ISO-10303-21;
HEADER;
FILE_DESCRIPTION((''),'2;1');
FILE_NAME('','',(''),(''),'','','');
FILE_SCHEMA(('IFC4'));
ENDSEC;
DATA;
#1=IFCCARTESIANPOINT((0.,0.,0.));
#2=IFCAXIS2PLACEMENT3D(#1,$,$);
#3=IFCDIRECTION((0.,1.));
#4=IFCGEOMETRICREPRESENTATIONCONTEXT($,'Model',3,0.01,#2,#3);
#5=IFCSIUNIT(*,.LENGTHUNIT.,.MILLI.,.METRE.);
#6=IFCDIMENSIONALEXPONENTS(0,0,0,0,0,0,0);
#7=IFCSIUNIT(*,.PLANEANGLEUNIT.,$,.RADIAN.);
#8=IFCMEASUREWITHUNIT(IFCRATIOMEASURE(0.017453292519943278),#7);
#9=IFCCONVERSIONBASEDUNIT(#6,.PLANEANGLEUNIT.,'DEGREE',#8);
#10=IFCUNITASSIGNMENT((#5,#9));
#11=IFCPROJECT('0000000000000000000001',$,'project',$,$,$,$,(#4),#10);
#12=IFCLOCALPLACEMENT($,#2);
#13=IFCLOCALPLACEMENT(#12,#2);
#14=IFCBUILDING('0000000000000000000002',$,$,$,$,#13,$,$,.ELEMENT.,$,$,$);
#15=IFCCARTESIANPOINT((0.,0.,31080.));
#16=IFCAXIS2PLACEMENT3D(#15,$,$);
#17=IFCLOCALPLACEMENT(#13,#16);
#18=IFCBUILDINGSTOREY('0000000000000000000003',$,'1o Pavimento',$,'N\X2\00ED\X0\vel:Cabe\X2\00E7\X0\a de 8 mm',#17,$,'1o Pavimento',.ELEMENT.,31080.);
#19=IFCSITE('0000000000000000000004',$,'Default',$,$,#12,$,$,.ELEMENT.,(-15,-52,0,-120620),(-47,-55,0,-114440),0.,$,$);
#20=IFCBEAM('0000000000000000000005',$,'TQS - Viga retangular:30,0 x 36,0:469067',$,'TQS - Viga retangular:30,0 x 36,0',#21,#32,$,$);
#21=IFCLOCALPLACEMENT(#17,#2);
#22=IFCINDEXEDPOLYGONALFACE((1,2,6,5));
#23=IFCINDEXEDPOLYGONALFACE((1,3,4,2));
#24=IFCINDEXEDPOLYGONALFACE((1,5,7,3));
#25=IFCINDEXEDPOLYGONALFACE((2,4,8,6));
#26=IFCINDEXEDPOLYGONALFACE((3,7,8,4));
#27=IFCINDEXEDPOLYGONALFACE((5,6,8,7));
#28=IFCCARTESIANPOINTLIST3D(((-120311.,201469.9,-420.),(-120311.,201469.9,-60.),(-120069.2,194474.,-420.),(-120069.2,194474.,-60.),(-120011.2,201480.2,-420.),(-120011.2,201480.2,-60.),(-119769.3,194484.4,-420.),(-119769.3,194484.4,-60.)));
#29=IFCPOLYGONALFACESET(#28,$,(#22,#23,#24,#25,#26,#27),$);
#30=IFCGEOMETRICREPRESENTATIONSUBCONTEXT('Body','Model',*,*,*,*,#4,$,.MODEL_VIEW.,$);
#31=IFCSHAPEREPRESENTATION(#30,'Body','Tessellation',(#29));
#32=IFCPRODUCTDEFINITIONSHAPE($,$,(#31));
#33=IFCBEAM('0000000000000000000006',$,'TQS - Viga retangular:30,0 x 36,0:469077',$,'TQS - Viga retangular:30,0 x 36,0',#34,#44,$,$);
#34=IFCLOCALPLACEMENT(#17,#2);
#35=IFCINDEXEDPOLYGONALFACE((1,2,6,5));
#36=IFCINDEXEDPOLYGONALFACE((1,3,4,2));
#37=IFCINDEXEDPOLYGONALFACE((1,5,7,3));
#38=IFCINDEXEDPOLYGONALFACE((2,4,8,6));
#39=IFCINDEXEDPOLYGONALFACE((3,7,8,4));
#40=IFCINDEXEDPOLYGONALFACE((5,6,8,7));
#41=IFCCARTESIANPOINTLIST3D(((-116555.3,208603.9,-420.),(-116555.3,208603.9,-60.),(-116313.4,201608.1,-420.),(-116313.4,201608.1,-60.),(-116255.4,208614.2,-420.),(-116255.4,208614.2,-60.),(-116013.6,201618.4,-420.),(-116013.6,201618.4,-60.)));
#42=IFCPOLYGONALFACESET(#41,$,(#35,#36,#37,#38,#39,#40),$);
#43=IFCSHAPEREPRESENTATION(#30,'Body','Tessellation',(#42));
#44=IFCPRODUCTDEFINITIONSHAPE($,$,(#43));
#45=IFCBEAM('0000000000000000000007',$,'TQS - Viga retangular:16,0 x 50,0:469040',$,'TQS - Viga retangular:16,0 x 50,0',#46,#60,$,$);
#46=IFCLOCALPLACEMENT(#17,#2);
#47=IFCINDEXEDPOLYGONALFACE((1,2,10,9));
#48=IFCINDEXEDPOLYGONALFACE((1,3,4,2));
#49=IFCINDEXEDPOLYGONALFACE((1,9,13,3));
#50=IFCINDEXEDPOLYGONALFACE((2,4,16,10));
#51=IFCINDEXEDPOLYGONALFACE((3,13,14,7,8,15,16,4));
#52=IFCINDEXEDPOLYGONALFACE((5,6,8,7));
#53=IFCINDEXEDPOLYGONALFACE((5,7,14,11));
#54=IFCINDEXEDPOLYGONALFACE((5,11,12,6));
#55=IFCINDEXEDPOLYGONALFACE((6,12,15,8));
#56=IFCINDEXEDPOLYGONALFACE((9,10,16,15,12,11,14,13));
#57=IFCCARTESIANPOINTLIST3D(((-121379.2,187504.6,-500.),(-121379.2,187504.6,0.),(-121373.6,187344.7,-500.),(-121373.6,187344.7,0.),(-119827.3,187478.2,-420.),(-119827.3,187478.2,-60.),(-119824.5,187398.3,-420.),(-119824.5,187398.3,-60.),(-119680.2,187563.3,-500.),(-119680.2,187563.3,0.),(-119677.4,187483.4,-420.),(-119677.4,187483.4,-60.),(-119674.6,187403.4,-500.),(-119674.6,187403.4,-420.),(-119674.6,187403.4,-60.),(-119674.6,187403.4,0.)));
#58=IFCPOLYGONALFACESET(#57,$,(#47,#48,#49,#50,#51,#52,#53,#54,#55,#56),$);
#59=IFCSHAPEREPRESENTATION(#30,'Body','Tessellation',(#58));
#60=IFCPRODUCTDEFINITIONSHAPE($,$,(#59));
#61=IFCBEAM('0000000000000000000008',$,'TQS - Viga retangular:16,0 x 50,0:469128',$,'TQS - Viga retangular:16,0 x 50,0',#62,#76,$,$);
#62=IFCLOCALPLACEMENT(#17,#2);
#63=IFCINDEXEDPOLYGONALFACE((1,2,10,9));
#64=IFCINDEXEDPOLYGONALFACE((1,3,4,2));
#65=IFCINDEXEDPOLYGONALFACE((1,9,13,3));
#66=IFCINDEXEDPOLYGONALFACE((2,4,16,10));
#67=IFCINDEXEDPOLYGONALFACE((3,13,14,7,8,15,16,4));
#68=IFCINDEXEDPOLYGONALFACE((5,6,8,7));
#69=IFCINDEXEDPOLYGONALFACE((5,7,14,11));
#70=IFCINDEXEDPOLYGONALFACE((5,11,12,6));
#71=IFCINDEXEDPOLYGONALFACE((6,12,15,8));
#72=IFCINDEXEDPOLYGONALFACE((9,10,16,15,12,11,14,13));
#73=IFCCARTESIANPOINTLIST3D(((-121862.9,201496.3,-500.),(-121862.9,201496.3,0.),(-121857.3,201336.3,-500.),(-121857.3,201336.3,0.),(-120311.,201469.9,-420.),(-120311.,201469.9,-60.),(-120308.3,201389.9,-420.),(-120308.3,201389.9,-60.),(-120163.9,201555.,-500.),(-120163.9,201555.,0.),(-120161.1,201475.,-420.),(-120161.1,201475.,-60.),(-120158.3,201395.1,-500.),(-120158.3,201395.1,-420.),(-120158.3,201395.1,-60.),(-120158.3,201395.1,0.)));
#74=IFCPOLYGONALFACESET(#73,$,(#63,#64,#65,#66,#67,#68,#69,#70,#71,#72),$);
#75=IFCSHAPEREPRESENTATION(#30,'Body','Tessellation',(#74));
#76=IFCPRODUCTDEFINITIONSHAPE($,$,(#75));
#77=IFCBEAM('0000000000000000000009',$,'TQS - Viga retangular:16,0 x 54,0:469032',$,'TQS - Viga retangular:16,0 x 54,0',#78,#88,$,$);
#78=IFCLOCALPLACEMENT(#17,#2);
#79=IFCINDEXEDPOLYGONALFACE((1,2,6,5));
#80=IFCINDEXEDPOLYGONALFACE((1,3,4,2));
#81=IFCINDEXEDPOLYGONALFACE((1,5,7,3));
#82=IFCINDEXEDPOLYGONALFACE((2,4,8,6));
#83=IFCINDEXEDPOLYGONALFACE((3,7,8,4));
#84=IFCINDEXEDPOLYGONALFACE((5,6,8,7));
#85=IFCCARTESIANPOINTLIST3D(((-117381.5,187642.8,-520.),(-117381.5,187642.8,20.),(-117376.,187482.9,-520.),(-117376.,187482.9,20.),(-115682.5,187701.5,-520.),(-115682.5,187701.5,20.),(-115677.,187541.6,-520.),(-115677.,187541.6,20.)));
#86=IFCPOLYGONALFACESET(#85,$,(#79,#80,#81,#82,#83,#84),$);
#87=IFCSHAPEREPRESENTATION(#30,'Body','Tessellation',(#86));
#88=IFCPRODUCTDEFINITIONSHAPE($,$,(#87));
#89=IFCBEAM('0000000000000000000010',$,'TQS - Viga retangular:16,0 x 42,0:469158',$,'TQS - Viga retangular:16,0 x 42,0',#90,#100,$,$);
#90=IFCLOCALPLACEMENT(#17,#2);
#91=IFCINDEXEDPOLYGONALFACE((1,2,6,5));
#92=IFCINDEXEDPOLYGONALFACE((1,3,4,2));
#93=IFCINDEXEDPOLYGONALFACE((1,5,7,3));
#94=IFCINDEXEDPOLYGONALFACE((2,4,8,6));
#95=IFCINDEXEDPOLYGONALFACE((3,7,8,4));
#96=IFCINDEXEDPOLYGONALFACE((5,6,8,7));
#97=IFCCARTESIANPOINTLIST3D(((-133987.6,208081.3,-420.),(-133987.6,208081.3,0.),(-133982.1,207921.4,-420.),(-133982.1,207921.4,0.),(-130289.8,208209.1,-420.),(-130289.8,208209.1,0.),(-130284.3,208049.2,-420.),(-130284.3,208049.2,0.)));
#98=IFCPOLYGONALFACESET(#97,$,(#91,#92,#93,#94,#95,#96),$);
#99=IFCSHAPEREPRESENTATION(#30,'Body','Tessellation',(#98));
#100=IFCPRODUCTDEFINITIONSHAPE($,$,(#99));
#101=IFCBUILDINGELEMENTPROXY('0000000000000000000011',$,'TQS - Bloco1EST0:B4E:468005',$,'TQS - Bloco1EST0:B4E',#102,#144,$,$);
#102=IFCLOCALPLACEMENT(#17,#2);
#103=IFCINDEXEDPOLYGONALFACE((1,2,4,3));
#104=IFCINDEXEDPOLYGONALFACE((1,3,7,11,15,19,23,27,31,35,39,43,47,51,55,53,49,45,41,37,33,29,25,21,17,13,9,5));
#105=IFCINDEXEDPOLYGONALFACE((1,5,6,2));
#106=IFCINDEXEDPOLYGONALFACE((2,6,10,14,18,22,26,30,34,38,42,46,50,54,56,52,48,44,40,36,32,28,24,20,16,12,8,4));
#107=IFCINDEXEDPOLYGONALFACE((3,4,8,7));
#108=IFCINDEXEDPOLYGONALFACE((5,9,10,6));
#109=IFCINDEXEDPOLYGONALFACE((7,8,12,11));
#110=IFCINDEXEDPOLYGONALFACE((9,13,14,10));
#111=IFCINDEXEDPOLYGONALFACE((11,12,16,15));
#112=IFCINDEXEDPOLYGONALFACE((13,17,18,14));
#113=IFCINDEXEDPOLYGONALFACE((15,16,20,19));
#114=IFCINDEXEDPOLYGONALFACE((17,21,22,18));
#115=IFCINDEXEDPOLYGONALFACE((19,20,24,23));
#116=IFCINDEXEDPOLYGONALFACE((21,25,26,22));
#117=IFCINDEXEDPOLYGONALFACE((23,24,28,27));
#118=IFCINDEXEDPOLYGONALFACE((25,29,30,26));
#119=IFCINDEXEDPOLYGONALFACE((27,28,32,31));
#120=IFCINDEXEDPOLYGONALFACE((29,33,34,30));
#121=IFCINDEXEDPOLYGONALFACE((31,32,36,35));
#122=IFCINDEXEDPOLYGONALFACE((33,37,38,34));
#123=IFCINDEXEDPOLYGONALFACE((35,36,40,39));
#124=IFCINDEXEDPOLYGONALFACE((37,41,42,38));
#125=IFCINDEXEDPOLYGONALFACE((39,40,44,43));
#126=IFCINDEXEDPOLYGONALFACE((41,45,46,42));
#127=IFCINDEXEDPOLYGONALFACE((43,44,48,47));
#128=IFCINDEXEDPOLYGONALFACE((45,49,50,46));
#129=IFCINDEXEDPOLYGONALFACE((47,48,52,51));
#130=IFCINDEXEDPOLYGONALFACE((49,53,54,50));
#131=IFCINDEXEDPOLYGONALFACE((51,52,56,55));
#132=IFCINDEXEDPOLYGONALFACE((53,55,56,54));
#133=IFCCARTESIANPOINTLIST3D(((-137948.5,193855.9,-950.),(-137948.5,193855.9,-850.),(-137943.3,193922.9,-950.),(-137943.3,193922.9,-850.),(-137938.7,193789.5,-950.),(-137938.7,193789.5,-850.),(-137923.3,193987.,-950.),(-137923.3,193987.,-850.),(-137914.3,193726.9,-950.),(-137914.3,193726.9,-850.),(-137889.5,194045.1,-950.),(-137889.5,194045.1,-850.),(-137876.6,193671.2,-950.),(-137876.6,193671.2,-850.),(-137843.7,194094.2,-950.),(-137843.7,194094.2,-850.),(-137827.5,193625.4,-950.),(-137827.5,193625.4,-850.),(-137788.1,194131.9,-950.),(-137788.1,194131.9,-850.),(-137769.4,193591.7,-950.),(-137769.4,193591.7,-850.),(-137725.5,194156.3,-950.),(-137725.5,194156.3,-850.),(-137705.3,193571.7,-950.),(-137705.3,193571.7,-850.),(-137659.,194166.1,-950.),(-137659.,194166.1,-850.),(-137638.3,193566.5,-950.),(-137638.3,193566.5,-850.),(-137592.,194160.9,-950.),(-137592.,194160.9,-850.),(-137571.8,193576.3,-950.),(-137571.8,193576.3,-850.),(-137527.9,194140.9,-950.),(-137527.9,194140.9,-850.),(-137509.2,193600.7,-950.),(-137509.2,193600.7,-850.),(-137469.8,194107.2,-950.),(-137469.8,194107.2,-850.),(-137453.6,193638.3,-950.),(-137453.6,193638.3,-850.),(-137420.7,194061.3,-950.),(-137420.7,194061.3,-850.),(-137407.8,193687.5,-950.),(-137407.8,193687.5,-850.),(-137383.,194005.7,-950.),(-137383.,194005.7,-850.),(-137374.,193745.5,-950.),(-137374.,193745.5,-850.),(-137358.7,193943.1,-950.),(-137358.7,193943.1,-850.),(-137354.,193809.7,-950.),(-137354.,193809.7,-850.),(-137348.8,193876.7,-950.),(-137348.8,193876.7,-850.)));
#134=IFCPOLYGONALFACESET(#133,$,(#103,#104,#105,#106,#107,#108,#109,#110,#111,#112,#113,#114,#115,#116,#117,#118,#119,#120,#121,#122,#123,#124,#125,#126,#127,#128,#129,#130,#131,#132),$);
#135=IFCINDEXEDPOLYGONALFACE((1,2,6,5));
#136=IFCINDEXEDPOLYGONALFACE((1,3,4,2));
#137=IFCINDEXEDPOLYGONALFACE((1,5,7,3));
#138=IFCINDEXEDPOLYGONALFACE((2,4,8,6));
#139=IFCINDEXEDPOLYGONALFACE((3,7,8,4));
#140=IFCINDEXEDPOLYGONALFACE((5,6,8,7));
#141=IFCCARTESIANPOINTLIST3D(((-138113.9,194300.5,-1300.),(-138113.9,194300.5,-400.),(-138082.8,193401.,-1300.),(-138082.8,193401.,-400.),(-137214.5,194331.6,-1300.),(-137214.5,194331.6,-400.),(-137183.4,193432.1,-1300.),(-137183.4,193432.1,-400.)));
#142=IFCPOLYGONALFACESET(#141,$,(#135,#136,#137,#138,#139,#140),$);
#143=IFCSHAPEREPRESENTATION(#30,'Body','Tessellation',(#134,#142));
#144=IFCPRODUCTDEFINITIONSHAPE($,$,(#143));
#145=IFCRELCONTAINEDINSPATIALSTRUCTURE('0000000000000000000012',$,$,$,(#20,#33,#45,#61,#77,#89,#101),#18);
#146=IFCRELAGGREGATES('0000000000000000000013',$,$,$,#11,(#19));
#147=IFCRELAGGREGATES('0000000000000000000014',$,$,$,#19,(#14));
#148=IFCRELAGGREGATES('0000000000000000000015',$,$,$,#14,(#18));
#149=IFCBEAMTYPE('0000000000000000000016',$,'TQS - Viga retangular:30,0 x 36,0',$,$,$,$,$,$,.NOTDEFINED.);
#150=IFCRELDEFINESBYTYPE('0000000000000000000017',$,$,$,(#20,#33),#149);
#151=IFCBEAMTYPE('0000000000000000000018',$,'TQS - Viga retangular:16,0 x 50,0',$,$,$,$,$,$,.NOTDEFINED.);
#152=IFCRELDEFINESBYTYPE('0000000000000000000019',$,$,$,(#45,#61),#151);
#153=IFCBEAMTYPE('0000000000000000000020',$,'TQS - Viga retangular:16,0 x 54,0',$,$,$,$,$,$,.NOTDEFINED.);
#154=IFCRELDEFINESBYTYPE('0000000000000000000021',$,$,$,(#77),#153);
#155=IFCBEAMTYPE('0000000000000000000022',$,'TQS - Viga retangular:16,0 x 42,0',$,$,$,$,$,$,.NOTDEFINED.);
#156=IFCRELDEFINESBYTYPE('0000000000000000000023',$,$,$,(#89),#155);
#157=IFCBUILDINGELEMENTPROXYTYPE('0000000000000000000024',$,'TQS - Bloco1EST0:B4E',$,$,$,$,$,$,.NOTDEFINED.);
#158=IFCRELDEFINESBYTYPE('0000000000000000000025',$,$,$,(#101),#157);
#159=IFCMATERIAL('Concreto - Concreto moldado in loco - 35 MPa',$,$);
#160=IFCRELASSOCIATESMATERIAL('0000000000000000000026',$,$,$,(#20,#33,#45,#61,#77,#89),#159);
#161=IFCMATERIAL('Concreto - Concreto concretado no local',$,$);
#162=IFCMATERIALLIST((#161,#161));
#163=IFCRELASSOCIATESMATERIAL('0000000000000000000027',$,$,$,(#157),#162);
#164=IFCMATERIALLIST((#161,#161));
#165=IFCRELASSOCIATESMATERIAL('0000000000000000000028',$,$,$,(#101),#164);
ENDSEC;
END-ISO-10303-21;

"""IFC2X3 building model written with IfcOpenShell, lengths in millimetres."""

from ifc_helpers import new_model, entity, si_unit, converted_unit, direction, frame, frame_2d, origin, origin_2d_with_axis, place, context, subcontext, project, spatial, polyline, rectangle, circle, extrude, boolean, clip, bounded_halfspace, source, transform, mapped, material, material_list, type_object, type_shapes, element, save


model = new_model("IFC2X3")

# Units and contexts
model_context = context("Model", 3, precision=0.01, world=origin(), true_north=direction((0.0, 1.0)))
body_context = subcontext(model_context, "Body", "Model", "MODEL_VIEW")
ifc_project = project(units=[si_unit("LENGTHUNIT", "METRE", prefix="MILLI"), converted_unit("PLANEANGLEUNIT", "DEGREE", entity("IfcRatioMeasure", 0.017453292519943278), si_unit("PLANEANGLEUNIT", "RADIAN"), dimensions=[0, 0, 0, 0, 0, 0, 0])], contexts=[model_context])

# Site, building, storey
site_placement = place(None, origin())
site = spatial("IfcSite", under=ifc_project, at=site_placement, Name="Default", CompositionType="ELEMENT", RefLatitude=(-15, -52, 0, -120620), RefLongitude=(-47, -55, 0, -114440), RefElevation=0.0)
building_placement = place(site_placement, origin())
building = spatial("IfcBuilding", under=site, at=building_placement, CompositionType="ELEMENT")
storey_placement = place(building_placement, frame((0.0, 0.0, 31080.0)))
storey = spatial("IfcBuildingStorey", under=building, at=storey_placement, Name="1o Pavimento", ObjectType="Nível:Cabeça de 8 mm", LongName="1o Pavimento", CompositionType="ELEMENT", Elevation=31080.0)

# Beams
ifc_material_1 = material(Name="Concreto - Concreto moldado in loco - 35 MPa")
beam_type_1 = type_object("IfcBeamType", Name="TQS - Viga retangular:30,0 x 36,0", PredefinedType="NOTDEFINED")
beam_1_placement = place(storey_placement, frame((-119919.3, 194479.2, -60.0), z_axis=(0.0, 0.0, 1.0), x_axis=(-0.034551, 0.999403, 0.0)))
element("IfcBeam", 1, at=beam_1_placement, inside=storey, type_object=beam_type_1, material=ifc_material_1, Name="TQS - Viga retangular:30,0 x 36,0:469067", ObjectType="TQS - Viga retangular:30,0 x 36,0", context=body_context, shape_type="SweptSolid", body=[
    extrude(rectangle(XDim=360.0, YDim=300.0, at=frame_2d((0.0, 0.0), x_axis=(1.0, 0.0))), frame((0.0, 0.0, -180.0), z_axis=(1.0, 0.0, 0.0), x_axis=(0.0, 0.0, -1.0)), (0.0, 0.0, 1.0), 7000.0),
])
beam_2_placement = place(storey_placement, frame((-116163.5, 201613.2, -60.0), z_axis=(0.0, 0.0, 1.0), x_axis=(-0.034551, 0.999403, 0.0)))
element("IfcBeam", 2, at=beam_2_placement, inside=storey, type_object=beam_type_1, material=ifc_material_1, Name="TQS - Viga retangular:30,0 x 36,0:469077", ObjectType="TQS - Viga retangular:30,0 x 36,0", context=body_context, shape_type="SweptSolid", body=[
    extrude(rectangle(XDim=360.0, YDim=300.0, at=frame_2d((0.0, 0.0), x_axis=(1.0, 0.0))), frame((0.0, 0.0, -180.0), z_axis=(1.0, 0.0, 0.0), x_axis=(0.0, 0.0, -1.0)), (0.0, 0.0, 1.0), 7000.0),
])
beam_type_2 = type_object("IfcBeamType", Name="TQS - Viga retangular:16,0 x 50,0", PredefinedType="NOTDEFINED")
beam_3_placement = place(storey_placement, frame((-119677.4, 187483.4, 0.0), z_axis=(0.0, 0.0, 1.0), x_axis=(-0.999403, -0.034551, 0.0)))
element("IfcBeam", 3, at=beam_3_placement, inside=storey, type_object=beam_type_2, material=ifc_material_1, Name="TQS - Viga retangular:16,0 x 50,0:469040", ObjectType="TQS - Viga retangular:16,0 x 50,0", context=body_context, shape_type="SweptSolid", body=[
    boolean("DIFFERENCE", clip(extrude(rectangle(XDim=500.0, YDim=160.0, at=origin_2d_with_axis()), frame((0.0, 0.0, -250.0), z_axis=(1.0, 0.0, 0.0), x_axis=(0.0, 0.0, -1.0)), (0.0, 0.0, 1.0), 1700.0), bounded_halfspace(frame((150.0, 0.0, -420.0), z_axis=(-1.0, 0.0, 0.0), x_axis=(0.0, 1.0, 0.0)), False, frame((0.0, 0.0, -250.0), z_axis=(1.0, 0.0, 0.0), x_axis=(0.0, 0.0, -1.0)), polyline([(170.0, 0.0), (-190.0, 0.0), (-190.0, 80.0), (-90.0, 80.0), (170.0, 80.0), (170.0, 0.0)]))), extrude(rectangle(XDim=360.0, YDim=80.0, at=frame_2d((0.0, 0.0), x_axis=(0.0, 1.0))), frame((0.0, 40.0, -240.0), z_axis=(-1.0, 0.0, 0.0), x_axis=(0.0, -1.0, 0.0)), (0.0, 0.0, -1.0), 150.0)),
])
beam_4_placement = place(storey_placement, frame((-120161.1, 201475.0, 0.0), z_axis=(0.0, 0.0, 1.0), x_axis=(-0.999403, -0.034551, 0.0)))
element("IfcBeam", 4, at=beam_4_placement, inside=storey, type_object=beam_type_2, material=ifc_material_1, Name="TQS - Viga retangular:16,0 x 50,0:469128", ObjectType="TQS - Viga retangular:16,0 x 50,0", context=body_context, shape_type="SweptSolid", body=[
    boolean("DIFFERENCE", clip(extrude(rectangle(XDim=500.0, YDim=160.0, at=frame_2d((0.0, 0.0), x_axis=(1.0, 0.0))), frame((0.0, 0.0, -250.0), z_axis=(1.0, 0.0, 0.0), x_axis=(0.0, 0.0, -1.0)), (0.0, 0.0, 1.0), 1700.0), bounded_halfspace(frame((150.0, 0.0, -420.0), z_axis=(-1.0, 0.0, 0.0), x_axis=(0.0, 1.0, 0.0)), False, frame((0.0, 0.0, -250.0), z_axis=(1.0, 0.0, 0.0), x_axis=(0.0, 0.0, -1.0)), polyline([(170.0, 0.0), (-190.0, 0.0), (-190.0, 80.0), (-90.0, 80.0), (170.0, 80.0), (170.0, 0.0)]))), extrude(rectangle(XDim=360.0, YDim=80.0, at=frame_2d((0.0, 0.0), x_axis=(0.0, 1.0))), frame((0.0, 40.0, -240.0), z_axis=(-1.0, 0.0, 0.0), x_axis=(0.0, -1.0, 0.0)), (0.0, 0.0, -1.0), 150.0)),
])
beam_type_3 = type_object("IfcBeamType", Name="TQS - Viga retangular:16,0 x 54,0", PredefinedType="NOTDEFINED")
beam_5_placement = place(storey_placement, frame((-115679.8, 187621.6, 20.0), z_axis=(0.0, 0.0, 1.0), x_axis=(-0.999403, -0.034551, 0.0)))
element("IfcBeam", 5, at=beam_5_placement, inside=storey, type_object=beam_type_3, material=ifc_material_1, Name="TQS - Viga retangular:16,0 x 54,0:469032", ObjectType="TQS - Viga retangular:16,0 x 54,0", context=body_context, shape_type="SweptSolid", body=[
    extrude(rectangle(XDim=540.0, YDim=160.0, at=frame_2d((0.0, 0.0), x_axis=(1.0, 0.0))), frame((0.0, 0.0, -270.0), z_axis=(1.0, 0.0, 0.0), x_axis=(0.0, 0.0, -1.0)), (0.0, 0.0, 1.0), 1700.0),
])
beam_type_4 = type_object("IfcBeamType", Name="TQS - Viga retangular:16,0 x 42,0", PredefinedType="NOTDEFINED")
beam_6_placement = place(storey_placement, frame((-130207.1, 208131.9, 0.0), z_axis=(0.0, 0.0, 1.0), x_axis=(-0.999403, -0.034551, 0.0)))
element("IfcBeam", 6, at=beam_6_placement, inside=storey, type_object=beam_type_4, material=ifc_material_1, Name="TQS - Viga retangular:16,0 x 42,0:469158", ObjectType="TQS - Viga retangular:16,0 x 42,0", context=body_context, shape_type="SweptSolid", body=[
    extrude(rectangle(XDim=420.0, YDim=160.0, at=frame_2d((0.0, 0.0), x_axis=(1.0, 0.0))), frame((80.0, 0.0, -210.0), z_axis=(1.0, 0.0, 0.0), x_axis=(0.0, 0.0, -1.0)), (0.0, 0.0, 1.0), 3700.0),
])

# Building element proxy
ifc_material_2 = material(Name="Concreto - Concreto concretado no local")
ifc_material_list_1 = material_list([ifc_material_2, ifc_material_2])
ifc_material_list_2 = material_list([ifc_material_2, ifc_material_2])
building_element_proxy_type_1 = type_object("IfcBuildingElementProxyType", Name="TQS - Bloco1EST0:B4E", PredefinedType="NOTDEFINED", material=ifc_material_list_2)
shared_shape_1 = source(origin(), body_context, "Body", "SweptSolid", [
    extrude(circle(Radius=300.0, at=frame_2d((0.0, 0.0), x_axis=(1.0, 0.0))), frame((0.0, 0.0, -550.0)), (0.0, 0.0, 1.0), 100.0),
    extrude(rectangle(XDim=900.0, YDim=900.0, at=origin_2d_with_axis()), frame((0.0, 0.0, -900.0), z_axis=(0.0, 0.0, 1.0), x_axis=(-1.0, 0.0, 0.0)), (0.0, 0.0, 1.0), 900.0),
])
type_shapes(building_element_proxy_type_1, [shared_shape_1])
proxy_1_placement = place(storey_placement, frame((-137648.7, 193866.3, -400.0), z_axis=(0.0, 0.0, 1.0), x_axis=(-0.034551, 0.999403, 0.0)))
element("IfcBuildingElementProxy", 7, at=proxy_1_placement, inside=storey, type_object=building_element_proxy_type_1, material=ifc_material_list_1, Name="TQS - Bloco1EST0:B4E:468005", ObjectType="TQS - Bloco1EST0:B4E", context=body_context, shape_type="MappedRepresentation", body=[
    mapped(shared_shape_1, transform((0.0, 0.0, 0.0), scale=1.0)),
])

save(model, "model.ifc")
